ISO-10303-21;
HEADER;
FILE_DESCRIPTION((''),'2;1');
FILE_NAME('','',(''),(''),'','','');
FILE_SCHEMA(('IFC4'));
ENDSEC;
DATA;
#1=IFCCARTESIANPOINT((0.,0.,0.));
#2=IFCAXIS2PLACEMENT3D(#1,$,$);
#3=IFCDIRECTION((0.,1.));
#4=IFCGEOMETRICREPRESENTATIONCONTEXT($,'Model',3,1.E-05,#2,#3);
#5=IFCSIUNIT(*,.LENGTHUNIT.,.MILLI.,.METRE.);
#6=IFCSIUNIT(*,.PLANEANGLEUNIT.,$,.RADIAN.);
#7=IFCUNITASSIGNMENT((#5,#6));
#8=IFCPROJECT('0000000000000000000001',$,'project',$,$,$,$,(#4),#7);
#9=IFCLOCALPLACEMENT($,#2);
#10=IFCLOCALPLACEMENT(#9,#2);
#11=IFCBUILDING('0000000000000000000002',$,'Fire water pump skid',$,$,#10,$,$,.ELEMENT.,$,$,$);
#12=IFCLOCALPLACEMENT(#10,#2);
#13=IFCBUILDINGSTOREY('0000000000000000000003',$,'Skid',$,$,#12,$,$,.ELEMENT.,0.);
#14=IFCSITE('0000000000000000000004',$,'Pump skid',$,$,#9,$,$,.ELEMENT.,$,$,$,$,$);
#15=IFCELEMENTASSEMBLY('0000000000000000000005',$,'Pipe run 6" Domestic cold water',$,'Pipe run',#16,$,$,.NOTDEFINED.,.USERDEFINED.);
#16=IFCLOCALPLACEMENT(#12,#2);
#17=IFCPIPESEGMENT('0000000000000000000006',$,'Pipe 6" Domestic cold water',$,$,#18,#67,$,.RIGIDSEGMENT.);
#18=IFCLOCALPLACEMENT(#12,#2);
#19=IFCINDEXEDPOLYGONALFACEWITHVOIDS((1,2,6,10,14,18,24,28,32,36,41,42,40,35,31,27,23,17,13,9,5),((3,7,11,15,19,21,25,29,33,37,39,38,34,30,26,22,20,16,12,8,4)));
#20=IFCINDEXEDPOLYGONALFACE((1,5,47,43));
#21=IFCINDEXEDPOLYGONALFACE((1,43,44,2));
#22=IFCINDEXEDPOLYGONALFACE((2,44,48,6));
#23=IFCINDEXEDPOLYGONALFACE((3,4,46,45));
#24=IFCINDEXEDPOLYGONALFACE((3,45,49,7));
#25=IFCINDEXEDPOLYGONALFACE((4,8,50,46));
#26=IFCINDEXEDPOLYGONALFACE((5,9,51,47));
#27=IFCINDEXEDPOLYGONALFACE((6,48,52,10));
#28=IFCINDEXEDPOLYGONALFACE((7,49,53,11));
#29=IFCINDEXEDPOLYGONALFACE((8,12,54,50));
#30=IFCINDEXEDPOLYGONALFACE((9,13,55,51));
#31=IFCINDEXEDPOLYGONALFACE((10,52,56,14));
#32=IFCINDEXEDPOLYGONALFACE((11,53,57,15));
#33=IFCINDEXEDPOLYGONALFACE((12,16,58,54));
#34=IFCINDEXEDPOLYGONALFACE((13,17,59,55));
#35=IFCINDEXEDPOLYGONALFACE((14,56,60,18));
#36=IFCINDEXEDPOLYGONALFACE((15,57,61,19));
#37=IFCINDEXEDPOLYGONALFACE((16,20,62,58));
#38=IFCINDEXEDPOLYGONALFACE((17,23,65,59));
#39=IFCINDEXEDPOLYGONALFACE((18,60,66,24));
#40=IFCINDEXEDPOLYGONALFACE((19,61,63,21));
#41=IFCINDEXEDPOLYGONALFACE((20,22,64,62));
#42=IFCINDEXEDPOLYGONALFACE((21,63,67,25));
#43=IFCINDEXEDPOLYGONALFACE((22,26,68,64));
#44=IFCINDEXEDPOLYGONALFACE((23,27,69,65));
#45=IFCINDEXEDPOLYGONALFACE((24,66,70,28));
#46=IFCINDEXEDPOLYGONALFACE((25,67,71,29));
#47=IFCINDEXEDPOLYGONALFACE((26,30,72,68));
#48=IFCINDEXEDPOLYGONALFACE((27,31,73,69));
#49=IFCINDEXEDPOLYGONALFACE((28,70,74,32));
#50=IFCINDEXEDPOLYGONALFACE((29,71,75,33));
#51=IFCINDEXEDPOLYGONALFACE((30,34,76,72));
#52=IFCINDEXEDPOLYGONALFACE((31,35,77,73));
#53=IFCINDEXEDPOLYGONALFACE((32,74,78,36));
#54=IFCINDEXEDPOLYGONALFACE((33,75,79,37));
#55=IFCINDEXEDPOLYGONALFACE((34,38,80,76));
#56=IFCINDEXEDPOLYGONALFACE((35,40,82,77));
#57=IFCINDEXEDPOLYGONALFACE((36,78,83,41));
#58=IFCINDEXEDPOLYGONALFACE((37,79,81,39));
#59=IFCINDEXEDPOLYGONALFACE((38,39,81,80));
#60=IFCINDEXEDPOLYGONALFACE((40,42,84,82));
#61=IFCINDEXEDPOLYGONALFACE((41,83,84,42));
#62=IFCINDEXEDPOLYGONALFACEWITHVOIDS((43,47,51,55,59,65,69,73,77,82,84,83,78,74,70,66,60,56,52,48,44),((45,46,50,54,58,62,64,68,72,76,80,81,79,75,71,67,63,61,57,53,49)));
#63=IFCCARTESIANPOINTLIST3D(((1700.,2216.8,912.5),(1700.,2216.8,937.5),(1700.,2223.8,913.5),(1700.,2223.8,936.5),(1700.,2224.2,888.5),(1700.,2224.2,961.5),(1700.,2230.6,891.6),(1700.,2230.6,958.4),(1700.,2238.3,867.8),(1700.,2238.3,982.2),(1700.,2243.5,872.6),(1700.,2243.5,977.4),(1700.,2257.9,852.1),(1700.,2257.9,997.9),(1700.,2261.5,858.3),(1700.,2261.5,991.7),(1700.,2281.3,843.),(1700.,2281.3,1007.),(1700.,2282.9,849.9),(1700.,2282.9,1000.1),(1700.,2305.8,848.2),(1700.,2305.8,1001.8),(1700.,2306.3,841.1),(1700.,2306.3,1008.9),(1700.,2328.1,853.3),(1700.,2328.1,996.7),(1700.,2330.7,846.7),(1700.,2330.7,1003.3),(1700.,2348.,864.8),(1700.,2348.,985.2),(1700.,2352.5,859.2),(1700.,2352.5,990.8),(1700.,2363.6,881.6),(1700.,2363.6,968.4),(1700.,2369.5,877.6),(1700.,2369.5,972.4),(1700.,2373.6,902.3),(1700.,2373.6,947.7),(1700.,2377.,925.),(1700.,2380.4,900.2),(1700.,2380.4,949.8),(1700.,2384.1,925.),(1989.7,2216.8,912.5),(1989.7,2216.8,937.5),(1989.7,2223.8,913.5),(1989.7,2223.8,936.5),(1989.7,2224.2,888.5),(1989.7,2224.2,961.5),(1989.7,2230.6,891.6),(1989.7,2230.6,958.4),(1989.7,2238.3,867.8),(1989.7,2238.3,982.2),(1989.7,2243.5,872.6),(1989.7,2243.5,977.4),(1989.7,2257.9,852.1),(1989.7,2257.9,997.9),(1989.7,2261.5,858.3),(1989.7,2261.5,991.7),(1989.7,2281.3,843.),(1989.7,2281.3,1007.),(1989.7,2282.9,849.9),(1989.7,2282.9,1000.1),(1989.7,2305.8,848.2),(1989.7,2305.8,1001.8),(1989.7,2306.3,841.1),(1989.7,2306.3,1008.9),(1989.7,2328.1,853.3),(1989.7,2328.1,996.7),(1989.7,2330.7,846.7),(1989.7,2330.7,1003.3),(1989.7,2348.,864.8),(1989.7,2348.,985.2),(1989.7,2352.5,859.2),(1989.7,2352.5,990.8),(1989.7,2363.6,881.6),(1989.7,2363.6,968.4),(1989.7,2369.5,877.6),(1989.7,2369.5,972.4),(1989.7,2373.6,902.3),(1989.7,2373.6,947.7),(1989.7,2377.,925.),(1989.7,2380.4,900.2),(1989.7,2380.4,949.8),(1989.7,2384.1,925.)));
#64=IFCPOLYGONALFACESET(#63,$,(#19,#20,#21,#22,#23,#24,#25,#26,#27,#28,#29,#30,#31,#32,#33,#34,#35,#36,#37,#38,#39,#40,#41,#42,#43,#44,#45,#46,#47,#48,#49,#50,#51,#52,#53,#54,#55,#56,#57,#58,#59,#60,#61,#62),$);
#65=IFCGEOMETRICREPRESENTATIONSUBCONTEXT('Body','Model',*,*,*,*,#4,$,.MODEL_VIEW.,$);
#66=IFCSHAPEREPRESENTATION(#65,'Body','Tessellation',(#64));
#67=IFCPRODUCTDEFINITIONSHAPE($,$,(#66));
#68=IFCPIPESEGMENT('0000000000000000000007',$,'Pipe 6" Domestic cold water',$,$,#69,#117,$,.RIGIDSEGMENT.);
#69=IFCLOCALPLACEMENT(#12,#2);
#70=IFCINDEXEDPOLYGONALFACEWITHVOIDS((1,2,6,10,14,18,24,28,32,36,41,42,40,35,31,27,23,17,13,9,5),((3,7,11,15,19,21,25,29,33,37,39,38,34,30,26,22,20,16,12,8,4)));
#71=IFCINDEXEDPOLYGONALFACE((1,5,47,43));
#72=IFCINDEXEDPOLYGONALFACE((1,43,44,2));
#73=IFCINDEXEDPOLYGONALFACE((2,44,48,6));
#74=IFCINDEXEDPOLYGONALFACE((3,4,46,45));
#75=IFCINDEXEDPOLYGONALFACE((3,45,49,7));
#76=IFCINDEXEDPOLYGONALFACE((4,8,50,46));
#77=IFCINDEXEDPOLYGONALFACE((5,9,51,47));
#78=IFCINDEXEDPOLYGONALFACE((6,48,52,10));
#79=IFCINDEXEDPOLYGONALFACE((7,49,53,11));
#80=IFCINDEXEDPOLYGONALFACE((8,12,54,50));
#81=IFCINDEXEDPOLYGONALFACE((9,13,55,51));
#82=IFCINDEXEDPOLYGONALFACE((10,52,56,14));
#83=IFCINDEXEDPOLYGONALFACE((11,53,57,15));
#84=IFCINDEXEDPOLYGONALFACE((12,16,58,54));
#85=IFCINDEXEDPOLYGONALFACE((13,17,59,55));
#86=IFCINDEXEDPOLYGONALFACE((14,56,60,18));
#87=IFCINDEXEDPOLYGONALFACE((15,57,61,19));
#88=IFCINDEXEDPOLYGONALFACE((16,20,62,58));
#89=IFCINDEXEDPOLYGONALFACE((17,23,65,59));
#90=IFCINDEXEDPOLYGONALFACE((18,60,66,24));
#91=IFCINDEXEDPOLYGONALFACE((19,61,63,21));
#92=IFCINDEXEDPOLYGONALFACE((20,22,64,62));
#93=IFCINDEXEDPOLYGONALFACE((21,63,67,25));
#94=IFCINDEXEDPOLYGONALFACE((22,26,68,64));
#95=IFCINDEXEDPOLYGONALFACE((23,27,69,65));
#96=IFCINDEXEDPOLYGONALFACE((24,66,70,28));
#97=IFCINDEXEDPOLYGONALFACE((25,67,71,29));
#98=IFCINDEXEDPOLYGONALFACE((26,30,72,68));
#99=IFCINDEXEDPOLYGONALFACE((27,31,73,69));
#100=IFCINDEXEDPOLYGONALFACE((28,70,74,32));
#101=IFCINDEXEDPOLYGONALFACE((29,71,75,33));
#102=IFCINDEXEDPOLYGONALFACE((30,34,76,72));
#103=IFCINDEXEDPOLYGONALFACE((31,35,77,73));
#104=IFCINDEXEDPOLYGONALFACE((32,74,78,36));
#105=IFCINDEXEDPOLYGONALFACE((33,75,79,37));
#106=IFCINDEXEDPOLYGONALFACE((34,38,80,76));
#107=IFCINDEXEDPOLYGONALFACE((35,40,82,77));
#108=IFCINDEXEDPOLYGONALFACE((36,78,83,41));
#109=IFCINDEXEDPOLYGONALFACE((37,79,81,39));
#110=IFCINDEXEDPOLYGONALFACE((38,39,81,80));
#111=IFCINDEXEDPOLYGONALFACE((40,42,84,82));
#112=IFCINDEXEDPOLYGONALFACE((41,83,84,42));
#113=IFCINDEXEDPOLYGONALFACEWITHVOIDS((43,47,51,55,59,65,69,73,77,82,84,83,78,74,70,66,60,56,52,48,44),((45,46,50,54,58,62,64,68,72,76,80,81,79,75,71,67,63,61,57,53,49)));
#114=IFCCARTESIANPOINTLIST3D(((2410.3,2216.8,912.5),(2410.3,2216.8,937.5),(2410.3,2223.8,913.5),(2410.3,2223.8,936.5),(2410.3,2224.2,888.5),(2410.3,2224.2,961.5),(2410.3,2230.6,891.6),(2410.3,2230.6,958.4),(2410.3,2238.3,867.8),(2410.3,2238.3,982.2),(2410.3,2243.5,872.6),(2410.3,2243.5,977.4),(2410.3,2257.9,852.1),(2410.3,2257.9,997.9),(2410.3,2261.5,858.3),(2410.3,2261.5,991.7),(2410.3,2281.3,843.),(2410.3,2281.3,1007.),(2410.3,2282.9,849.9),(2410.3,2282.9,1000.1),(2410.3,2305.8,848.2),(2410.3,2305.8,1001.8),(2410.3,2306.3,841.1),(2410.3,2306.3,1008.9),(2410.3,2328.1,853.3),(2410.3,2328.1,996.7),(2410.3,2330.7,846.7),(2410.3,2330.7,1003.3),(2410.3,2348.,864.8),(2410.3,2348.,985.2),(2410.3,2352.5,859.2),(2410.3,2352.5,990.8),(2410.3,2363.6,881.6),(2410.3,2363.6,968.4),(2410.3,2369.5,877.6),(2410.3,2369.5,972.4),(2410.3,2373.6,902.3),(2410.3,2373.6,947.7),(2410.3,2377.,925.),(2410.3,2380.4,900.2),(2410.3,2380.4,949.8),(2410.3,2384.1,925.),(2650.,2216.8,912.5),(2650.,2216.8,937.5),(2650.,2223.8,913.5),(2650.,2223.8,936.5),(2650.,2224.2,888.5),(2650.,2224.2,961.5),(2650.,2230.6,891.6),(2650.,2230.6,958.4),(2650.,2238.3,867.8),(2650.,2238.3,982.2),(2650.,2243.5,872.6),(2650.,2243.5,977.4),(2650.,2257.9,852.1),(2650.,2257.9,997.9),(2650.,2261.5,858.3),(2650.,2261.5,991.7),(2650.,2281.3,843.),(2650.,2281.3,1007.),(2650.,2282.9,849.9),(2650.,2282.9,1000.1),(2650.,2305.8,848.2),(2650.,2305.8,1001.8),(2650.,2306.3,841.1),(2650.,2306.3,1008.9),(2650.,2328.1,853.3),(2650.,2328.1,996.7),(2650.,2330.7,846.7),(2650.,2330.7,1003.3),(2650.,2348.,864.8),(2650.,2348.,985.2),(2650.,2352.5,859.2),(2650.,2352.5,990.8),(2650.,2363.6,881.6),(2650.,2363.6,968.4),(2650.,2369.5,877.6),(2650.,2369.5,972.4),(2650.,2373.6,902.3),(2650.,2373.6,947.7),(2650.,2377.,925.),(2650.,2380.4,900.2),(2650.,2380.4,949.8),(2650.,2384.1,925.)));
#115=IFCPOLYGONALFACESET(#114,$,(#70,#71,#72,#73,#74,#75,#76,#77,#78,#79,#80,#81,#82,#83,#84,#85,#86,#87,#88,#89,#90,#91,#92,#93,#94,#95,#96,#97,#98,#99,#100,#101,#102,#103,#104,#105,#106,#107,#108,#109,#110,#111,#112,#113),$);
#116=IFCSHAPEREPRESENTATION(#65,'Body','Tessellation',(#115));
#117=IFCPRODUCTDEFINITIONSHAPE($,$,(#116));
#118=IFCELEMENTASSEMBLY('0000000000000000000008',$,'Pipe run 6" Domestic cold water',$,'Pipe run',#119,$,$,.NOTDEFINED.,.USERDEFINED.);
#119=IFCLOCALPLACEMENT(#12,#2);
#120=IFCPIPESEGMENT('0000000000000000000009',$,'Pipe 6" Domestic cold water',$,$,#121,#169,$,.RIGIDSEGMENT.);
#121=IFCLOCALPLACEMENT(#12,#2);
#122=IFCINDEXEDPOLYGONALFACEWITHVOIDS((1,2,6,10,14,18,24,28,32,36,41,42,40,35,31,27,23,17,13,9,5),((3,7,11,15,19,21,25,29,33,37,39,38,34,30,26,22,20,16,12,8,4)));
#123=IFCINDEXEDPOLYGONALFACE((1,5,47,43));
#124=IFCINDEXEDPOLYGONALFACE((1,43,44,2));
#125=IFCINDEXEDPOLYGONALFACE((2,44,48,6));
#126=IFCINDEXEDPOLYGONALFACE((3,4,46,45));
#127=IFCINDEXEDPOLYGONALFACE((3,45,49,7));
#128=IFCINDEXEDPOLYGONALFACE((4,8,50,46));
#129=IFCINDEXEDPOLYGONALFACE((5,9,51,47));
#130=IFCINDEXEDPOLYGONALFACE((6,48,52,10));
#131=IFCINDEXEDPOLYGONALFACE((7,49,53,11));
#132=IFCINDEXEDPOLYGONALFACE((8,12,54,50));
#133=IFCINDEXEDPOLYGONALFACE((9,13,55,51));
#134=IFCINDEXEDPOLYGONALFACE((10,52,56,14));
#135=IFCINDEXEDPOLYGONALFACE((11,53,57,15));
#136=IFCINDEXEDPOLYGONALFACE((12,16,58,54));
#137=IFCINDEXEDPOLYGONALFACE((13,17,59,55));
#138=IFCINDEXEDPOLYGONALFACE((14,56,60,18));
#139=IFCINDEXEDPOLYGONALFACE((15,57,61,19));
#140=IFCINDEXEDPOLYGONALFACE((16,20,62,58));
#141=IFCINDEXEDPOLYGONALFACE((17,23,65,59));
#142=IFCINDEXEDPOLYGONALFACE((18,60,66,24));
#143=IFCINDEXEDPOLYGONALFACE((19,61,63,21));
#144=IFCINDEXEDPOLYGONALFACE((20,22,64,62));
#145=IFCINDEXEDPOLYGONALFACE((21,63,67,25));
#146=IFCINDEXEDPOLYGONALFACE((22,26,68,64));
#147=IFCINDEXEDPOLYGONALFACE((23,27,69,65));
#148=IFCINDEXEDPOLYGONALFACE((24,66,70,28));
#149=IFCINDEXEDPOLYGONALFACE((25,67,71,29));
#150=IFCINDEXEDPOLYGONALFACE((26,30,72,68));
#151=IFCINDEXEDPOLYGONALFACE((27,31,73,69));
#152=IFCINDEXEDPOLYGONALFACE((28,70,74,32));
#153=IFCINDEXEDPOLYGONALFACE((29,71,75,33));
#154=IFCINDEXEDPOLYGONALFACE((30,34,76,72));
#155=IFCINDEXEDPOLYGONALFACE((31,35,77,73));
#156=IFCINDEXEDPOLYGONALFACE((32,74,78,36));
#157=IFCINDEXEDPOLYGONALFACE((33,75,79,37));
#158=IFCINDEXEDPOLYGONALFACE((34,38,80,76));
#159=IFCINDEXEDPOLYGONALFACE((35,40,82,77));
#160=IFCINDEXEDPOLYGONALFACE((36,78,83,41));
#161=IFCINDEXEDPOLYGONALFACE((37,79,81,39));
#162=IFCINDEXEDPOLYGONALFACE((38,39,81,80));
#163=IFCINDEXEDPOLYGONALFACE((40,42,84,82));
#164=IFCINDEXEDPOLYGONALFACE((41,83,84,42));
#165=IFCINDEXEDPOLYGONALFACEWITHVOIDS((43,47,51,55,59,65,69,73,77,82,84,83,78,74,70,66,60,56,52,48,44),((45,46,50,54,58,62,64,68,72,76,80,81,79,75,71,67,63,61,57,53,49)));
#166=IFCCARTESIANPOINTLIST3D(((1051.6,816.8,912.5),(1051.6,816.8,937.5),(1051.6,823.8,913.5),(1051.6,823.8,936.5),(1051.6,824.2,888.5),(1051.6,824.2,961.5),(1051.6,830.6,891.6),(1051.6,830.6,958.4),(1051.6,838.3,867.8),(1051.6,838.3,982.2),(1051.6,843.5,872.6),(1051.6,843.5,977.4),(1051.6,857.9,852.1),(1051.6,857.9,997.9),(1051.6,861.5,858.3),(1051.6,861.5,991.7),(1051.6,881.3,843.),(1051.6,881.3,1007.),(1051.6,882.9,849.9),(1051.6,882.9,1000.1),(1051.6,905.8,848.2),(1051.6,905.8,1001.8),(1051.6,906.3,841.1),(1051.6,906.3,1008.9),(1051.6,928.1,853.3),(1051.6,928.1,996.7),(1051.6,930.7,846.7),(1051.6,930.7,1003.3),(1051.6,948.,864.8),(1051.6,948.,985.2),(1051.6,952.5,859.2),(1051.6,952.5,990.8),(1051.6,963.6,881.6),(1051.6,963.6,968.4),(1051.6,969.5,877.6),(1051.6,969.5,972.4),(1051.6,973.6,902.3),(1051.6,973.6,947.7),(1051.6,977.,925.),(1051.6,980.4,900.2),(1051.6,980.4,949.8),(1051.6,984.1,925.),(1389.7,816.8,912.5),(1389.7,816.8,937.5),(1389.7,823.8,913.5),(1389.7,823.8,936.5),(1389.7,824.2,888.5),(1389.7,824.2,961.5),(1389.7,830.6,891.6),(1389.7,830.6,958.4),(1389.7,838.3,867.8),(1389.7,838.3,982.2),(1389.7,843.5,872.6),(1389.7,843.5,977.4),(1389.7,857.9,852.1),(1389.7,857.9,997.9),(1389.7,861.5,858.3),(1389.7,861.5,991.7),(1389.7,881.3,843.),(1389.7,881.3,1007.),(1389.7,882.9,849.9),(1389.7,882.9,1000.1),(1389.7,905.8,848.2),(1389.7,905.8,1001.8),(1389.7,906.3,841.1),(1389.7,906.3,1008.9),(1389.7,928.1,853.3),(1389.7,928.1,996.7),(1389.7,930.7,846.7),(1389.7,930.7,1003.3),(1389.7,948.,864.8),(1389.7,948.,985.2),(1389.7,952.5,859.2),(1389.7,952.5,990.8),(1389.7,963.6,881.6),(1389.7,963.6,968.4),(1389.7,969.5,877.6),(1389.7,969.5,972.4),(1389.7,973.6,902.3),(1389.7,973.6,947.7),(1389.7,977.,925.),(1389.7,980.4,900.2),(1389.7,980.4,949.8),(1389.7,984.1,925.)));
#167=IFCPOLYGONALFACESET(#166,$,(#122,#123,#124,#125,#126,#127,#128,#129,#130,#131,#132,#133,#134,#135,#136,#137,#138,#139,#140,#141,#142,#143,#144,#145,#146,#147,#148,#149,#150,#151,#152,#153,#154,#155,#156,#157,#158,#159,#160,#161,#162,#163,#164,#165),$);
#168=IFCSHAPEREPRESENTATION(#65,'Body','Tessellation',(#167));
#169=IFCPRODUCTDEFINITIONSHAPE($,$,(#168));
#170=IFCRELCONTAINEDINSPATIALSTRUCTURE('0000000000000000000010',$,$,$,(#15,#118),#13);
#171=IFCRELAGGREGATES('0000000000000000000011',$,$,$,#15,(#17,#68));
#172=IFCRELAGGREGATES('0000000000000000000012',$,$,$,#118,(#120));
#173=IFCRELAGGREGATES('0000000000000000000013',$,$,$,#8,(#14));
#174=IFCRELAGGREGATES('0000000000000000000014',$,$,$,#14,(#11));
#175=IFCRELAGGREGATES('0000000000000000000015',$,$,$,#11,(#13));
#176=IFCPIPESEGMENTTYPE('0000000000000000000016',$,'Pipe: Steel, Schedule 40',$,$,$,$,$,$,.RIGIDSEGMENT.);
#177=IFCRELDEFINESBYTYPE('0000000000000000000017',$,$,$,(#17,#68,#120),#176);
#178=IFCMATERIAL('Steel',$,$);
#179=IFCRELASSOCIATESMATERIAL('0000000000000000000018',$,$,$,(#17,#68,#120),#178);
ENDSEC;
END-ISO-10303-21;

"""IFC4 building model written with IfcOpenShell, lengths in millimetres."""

from ifc_helpers import new_model, si_unit, direction, frame, origin, origin_with_axes, origin_2d, place, context, subcontext, project, spatial, hollow_circle, extrude, material, type_object, element, aggregate, save


model = new_model("IFC4")

# Units and contexts
model_context = context("Model", 3, precision=1e-05, world=origin(), true_north=direction((0.0, 1.0)))
body_context = subcontext(model_context, "Body", "Model", "MODEL_VIEW")
ifc_project = project(units=[si_unit("LENGTHUNIT", "METRE", prefix="MILLI"), si_unit("PLANEANGLEUNIT", "RADIAN")], contexts=[model_context])

# Site, building, storey
site_placement = place(None, origin())
site = spatial("IfcSite", under=ifc_project, at=site_placement, Name="Pump skid", CompositionType="ELEMENT")
building_placement = place(site_placement, origin())
building = spatial("IfcBuilding", under=site, at=building_placement, Name="Fire water pump skid", CompositionType="ELEMENT")
storey_placement = place(building_placement, origin())
storey = spatial("IfcBuildingStorey", under=building, at=storey_placement, Name="Skid", CompositionType="ELEMENT", Elevation=0.0)

# Element assemblies, pipe segments
assembly_1_placement = place(storey_placement, origin_with_axes())
assembly_1 = element("IfcElementAssembly", 1, at=assembly_1_placement, inside=storey, Name="Pipe run 6\" Domestic cold water", ObjectType="Pipe run", AssemblyPlace="NOTDEFINED", PredefinedType="USERDEFINED")
ifc_material = material(Name="Steel")
pipe_segment_type = type_object("IfcPipeSegmentType", Name="Pipe: Steel, Schedule 40", PredefinedType="RIGIDSEGMENT")
pipe_segment_1_placement = place(storey_placement, origin_with_axes())
pipe_segment_1 = element("IfcPipeSegment", 2, at=pipe_segment_1_placement, type_object=pipe_segment_type, material=ifc_material, Name="Pipe 6\" Domestic cold water", PredefinedType="RIGIDSEGMENT", context=body_context, shape_type="SweptSolid", body=[
    extrude(hollow_circle(Radius=84.1, WallThickness=7.1, at=origin_2d()), frame((1700.0, 2300.0, 925.0), z_axis=(1.0, 0.0, 0.0), x_axis=(0.0, 1.0, 0.0)), (0.0, 0.0, 1.0), 289.7),
])
pipe_segment_2_placement = place(storey_placement, origin_with_axes())
pipe_segment_2 = element("IfcPipeSegment", 3, at=pipe_segment_2_placement, type_object=pipe_segment_type, material=ifc_material, Name="Pipe 6\" Domestic cold water", PredefinedType="RIGIDSEGMENT", context=body_context, shape_type="SweptSolid", body=[
    extrude(hollow_circle(Radius=84.1, WallThickness=7.1, at=origin_2d()), frame((2410.3, 2300.0, 925.0), z_axis=(1.0, 0.0, 0.0), x_axis=(0.0, 1.0, 0.0)), (0.0, 0.0, 1.0), 239.7),
])
assembly_2_placement = place(storey_placement, origin_with_axes())
assembly_2 = element("IfcElementAssembly", 4, at=assembly_2_placement, inside=storey, Name="Pipe run 6\" Domestic cold water", ObjectType="Pipe run", AssemblyPlace="NOTDEFINED", PredefinedType="USERDEFINED")
pipe_segment_3_placement = place(storey_placement, origin_with_axes())
pipe_segment_3 = element("IfcPipeSegment", 5, at=pipe_segment_3_placement, type_object=pipe_segment_type, material=ifc_material, Name="Pipe 6\" Domestic cold water", PredefinedType="RIGIDSEGMENT", context=body_context, shape_type="SweptSolid", body=[
    extrude(hollow_circle(Radius=84.1, WallThickness=7.1, at=origin_2d()), frame((1051.6, 900.0, 925.0), z_axis=(1.0, 0.0, 0.0), x_axis=(0.0, 1.0, 0.0)), (0.0, 0.0, 1.0), 338.1),
])

aggregate(assembly_1, [pipe_segment_1, pipe_segment_2])
aggregate(assembly_2, [pipe_segment_3])

save(model, "model.ifc")
